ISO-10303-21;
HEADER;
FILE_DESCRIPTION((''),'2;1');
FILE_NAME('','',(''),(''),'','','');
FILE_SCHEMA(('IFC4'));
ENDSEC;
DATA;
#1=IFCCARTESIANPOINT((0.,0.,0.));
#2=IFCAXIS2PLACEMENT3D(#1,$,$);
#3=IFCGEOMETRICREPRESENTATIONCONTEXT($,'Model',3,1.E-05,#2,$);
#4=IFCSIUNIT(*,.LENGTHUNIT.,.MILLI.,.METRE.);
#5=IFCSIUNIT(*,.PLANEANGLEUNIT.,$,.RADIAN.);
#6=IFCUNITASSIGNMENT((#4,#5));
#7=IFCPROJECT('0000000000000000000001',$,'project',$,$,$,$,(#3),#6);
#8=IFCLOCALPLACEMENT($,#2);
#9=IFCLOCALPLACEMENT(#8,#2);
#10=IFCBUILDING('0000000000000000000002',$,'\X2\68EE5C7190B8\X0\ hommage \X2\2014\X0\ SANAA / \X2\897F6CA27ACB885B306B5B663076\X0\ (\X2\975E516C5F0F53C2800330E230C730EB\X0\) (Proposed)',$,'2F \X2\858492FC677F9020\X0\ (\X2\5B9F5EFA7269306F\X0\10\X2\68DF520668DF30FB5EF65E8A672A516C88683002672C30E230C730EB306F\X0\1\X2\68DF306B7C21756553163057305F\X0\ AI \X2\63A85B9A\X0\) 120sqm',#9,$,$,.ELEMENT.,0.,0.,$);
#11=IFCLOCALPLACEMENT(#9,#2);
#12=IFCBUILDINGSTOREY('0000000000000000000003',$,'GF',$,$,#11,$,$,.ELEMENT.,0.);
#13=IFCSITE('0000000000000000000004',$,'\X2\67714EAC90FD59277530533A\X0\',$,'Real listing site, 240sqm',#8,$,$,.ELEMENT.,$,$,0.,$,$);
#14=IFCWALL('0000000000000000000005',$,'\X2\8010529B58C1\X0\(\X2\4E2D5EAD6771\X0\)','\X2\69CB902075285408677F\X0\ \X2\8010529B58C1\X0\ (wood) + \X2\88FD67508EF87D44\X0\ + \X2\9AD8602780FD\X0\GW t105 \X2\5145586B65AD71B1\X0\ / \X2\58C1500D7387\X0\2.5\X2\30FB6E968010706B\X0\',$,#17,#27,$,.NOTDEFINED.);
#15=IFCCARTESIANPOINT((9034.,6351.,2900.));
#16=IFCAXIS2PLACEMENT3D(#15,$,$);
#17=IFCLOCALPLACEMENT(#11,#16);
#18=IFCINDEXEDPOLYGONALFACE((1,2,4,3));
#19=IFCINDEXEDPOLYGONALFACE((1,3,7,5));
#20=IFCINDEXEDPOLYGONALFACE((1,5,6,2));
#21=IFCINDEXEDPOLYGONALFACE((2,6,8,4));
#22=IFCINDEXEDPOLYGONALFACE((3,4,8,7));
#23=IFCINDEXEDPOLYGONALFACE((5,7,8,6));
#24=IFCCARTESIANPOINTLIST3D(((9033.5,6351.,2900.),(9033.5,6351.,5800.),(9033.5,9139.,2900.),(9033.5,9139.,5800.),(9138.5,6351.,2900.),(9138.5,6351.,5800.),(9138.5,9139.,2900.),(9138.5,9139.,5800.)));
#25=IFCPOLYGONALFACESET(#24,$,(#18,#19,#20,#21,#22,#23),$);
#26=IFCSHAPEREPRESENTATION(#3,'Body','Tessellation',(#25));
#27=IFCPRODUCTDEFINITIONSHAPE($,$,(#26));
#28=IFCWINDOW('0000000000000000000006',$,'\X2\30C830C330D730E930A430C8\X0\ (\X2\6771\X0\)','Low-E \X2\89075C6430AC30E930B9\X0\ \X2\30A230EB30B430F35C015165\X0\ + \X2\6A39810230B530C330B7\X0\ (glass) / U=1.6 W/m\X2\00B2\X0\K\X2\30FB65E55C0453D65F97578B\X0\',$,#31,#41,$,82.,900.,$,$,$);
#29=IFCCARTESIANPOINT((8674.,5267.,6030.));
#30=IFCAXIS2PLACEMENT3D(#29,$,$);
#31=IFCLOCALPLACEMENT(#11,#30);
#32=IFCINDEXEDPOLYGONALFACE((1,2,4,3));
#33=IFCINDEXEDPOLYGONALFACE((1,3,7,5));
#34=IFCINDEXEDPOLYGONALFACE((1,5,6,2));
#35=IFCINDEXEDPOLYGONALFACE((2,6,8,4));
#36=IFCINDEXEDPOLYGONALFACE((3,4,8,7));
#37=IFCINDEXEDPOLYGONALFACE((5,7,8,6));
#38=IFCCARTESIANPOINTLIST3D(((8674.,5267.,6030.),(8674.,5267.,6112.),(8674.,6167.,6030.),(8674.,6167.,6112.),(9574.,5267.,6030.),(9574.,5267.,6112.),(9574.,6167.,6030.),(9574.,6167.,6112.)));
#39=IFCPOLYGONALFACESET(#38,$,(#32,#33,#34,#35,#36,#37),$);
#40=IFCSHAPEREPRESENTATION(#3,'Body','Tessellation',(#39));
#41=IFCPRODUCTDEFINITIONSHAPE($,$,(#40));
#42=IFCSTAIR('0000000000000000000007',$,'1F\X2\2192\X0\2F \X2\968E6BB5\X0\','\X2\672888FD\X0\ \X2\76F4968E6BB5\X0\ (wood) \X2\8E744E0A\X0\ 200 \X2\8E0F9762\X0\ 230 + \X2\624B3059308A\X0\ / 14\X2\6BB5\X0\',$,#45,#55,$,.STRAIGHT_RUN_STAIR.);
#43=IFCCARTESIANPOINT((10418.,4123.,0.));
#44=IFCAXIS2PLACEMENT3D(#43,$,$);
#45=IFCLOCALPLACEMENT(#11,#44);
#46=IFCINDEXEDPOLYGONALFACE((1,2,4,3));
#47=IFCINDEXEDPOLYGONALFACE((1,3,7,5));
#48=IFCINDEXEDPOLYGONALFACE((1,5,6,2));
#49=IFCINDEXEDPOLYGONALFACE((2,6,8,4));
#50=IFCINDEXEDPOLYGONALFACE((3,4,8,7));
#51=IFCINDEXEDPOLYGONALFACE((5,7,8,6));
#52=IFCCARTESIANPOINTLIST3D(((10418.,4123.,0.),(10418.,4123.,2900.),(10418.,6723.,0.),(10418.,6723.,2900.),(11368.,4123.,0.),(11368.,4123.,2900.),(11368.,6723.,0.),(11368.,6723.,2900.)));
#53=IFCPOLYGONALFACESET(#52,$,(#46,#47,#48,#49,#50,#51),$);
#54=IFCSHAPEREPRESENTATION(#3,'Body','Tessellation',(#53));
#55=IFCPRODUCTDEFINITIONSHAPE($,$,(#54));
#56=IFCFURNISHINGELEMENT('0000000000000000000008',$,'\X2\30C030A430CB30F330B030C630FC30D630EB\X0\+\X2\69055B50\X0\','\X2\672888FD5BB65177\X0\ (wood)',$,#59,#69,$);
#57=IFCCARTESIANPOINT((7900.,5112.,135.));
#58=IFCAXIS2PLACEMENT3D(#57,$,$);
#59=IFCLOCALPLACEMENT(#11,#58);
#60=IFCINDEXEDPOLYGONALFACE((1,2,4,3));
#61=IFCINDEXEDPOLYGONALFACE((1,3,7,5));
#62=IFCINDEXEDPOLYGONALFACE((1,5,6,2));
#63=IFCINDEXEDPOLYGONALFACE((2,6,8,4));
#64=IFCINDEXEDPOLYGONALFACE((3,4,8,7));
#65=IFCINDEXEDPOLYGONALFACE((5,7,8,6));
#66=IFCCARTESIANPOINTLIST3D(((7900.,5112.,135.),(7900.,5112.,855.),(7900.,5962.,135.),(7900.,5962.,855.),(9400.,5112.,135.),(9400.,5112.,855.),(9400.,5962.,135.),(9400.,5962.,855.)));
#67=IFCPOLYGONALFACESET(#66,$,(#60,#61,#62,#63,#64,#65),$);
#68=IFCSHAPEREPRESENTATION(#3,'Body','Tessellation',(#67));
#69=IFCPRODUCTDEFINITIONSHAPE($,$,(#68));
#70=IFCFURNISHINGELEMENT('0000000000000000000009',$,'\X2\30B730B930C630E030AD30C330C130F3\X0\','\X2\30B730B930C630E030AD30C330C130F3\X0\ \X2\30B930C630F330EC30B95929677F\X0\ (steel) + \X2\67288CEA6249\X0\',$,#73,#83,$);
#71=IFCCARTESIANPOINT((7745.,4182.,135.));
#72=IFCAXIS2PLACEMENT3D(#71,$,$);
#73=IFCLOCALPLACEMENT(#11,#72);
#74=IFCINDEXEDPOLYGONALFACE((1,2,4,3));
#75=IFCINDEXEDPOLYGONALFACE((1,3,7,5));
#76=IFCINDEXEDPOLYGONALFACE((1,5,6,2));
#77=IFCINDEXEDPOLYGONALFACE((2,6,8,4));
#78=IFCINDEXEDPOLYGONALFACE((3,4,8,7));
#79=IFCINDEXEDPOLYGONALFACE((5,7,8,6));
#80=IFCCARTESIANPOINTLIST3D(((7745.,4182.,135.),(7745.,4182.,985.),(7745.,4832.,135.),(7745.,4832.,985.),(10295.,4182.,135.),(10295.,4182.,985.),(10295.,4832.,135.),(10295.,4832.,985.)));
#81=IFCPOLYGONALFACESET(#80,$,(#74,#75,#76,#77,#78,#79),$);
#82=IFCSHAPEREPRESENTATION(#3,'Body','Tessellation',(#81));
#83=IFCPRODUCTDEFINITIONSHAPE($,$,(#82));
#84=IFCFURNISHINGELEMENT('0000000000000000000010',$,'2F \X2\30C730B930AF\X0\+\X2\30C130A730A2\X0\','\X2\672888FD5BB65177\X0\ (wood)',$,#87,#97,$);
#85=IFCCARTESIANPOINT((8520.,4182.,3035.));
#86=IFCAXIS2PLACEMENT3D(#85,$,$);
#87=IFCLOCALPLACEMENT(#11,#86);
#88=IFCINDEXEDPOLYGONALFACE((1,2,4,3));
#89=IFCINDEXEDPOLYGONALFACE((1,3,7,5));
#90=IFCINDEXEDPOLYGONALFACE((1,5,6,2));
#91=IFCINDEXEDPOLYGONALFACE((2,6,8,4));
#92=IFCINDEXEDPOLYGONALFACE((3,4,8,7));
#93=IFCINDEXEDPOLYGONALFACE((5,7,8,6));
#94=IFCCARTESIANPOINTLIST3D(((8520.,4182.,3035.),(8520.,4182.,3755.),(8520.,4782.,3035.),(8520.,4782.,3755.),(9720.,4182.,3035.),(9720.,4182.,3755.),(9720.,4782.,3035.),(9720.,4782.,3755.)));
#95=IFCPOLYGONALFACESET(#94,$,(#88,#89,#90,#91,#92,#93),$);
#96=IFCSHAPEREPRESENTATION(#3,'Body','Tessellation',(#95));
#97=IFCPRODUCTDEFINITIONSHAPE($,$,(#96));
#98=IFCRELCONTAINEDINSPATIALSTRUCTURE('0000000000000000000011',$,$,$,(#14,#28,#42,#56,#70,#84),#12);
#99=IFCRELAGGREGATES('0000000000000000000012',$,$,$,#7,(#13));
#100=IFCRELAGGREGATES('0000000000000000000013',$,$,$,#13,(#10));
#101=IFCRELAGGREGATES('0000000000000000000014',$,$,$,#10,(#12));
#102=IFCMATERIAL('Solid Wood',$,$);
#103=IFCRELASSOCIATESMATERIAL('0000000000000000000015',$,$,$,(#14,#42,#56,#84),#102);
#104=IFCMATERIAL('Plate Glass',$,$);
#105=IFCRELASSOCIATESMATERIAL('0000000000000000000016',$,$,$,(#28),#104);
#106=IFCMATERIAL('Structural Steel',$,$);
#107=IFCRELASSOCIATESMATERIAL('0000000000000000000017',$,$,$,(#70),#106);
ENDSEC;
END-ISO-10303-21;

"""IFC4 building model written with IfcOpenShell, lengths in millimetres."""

from ifc_helpers import new_model, si_unit, frame, frame_2d, origin, place, context, project, spatial, rectangle, extrude, material, element, save


model = new_model("IFC4")

# Units and contexts
model_context = context("Model", 3, precision=1e-05, world=origin())
ifc_project = project(units=[si_unit("LENGTHUNIT", "METRE", prefix="MILLI"), si_unit("PLANEANGLEUNIT", "RADIAN")], contexts=[model_context])

# Site, building, storey
site_placement = place(None, origin())
site = spatial("IfcSite", under=ifc_project, at=site_placement, Name="東京都大田区", ObjectType="Real listing site, 240sqm", CompositionType="ELEMENT", RefElevation=0.0)
building_placement = place(site_placement, origin())
building = spatial("IfcBuilding", under=site, at=building_placement, Name="森山邸 hommage — SANAA / 西沢立衛に学ぶ (非公式参考モデル) (Proposed)", ObjectType="2F 薄鋼板造 (実建物は10棟分棟・延床未公表。本モデルは1棟に簡略化した AI 推定) 120sqm", CompositionType="ELEMENT", ElevationOfRefHeight=0.0, ElevationOfTerrain=0.0)
storey_placement = place(building_placement, origin())
storey = spatial("IfcBuildingStorey", under=building, at=storey_placement, Name="GF", CompositionType="ELEMENT", Elevation=0.0)

# Shared definitions
ifc_material_1 = material(Name="Solid Wood")

# Shared definitions
ifc_material_2 = material(Name="Plate Glass")

# Wall
wall_1_placement = place(storey_placement, frame((9034.0, 6351.0, 2900.0)))
element("IfcWall", 1, at=wall_1_placement, inside=storey, material=ifc_material_1, Name="耐力壁(中庭東)", Description="構造用合板 耐力壁 (wood) + 製材軸組 + 高性能GW t105 充填断熱 / 壁倍率2.5・準耐火", PredefinedType="NOTDEFINED", context=model_context, shape_type="SweptSolid", body=[
    extrude(rectangle(XDim=105.0, YDim=2788.0, at=frame_2d((52.0, 1394.0))), frame((9034.0, 6351.0, 2900.0)), (0.0, 0.0, 1.0), 2900.0),
])

# Window
window_1_placement = place(storey_placement, frame((8674.0, 5267.0, 6030.0)))
element("IfcWindow", 2, at=window_1_placement, inside=storey, material=ifc_material_2, Name="トップライト (東)", Description="Low-E 複層ガラス アルゴン封入 + 樹脂サッシ (glass) / U=1.6 W/m²K・日射取得型", OverallHeight=82.0, OverallWidth=900.0, context=model_context, shape_type="SweptSolid", body=[
    extrude(rectangle(XDim=900.0, YDim=900.0, at=frame_2d((450.0, 450.0))), frame((8674.0, 5267.0, 6030.0)), (0.0, 0.0, 1.0), 82.0),
])

# Stair
stair_placement = place(storey_placement, frame((10418.0, 4123.0, 0.0)))
element("IfcStair", 3, at=stair_placement, inside=storey, material=ifc_material_1, Name="1F→2F 階段", Description="木製 直階段 (wood) 蹴上 200 踏面 230 + 手すり / 14段", PredefinedType="STRAIGHT_RUN_STAIR", context=model_context, shape_type="SweptSolid", body=[
    extrude(rectangle(XDim=950.0, YDim=2600.0, at=frame_2d((475.0, 1300.0))), frame((10418.0, 4123.0, 0.0)), (0.0, 0.0, 1.0), 2900.0),
])

# Furnishing elements
furnishing_1_placement = place(storey_placement, frame((7900.0, 5112.0, 135.0)))
element("IfcFurnishingElement", 4, at=furnishing_1_placement, inside=storey, material=ifc_material_1, Name="ダイニングテーブル+椅子", Description="木製家具 (wood)", context=model_context, shape_type="SweptSolid", body=[
    extrude(rectangle(XDim=1500.0, YDim=850.0, at=frame_2d((750.0, 425.0))), frame((7900.0, 5112.0, 135.0)), (0.0, 0.0, 1.0), 720.0),
])
ifc_material_3 = material(Name="Structural Steel")
furnishing_2_placement = place(storey_placement, frame((7745.0, 4182.0, 135.0)))
element("IfcFurnishingElement", 5, at=furnishing_2_placement, inside=storey, material=ifc_material_3, Name="システムキッチン", Description="システムキッチン ステンレス天板 (steel) + 木質扉", context=model_context, shape_type="SweptSolid", body=[
    extrude(rectangle(XDim=2550.0, YDim=650.0, at=frame_2d((1275.0, 325.0))), frame((7745.0, 4182.0, 135.0)), (0.0, 0.0, 1.0), 850.0),
])
furnishing_3_placement = place(storey_placement, frame((8520.0, 4182.0, 3035.0)))
element("IfcFurnishingElement", 6, at=furnishing_3_placement, inside=storey, material=ifc_material_1, Name="2F デスク+チェア", Description="木製家具 (wood)", context=model_context, shape_type="SweptSolid", body=[
    extrude(rectangle(XDim=1200.0, YDim=600.0, at=frame_2d((600.0, 300.0))), frame((8520.0, 4182.0, 3035.0)), (0.0, 0.0, 1.0), 720.0),
])

save(model, "model.ifc")
